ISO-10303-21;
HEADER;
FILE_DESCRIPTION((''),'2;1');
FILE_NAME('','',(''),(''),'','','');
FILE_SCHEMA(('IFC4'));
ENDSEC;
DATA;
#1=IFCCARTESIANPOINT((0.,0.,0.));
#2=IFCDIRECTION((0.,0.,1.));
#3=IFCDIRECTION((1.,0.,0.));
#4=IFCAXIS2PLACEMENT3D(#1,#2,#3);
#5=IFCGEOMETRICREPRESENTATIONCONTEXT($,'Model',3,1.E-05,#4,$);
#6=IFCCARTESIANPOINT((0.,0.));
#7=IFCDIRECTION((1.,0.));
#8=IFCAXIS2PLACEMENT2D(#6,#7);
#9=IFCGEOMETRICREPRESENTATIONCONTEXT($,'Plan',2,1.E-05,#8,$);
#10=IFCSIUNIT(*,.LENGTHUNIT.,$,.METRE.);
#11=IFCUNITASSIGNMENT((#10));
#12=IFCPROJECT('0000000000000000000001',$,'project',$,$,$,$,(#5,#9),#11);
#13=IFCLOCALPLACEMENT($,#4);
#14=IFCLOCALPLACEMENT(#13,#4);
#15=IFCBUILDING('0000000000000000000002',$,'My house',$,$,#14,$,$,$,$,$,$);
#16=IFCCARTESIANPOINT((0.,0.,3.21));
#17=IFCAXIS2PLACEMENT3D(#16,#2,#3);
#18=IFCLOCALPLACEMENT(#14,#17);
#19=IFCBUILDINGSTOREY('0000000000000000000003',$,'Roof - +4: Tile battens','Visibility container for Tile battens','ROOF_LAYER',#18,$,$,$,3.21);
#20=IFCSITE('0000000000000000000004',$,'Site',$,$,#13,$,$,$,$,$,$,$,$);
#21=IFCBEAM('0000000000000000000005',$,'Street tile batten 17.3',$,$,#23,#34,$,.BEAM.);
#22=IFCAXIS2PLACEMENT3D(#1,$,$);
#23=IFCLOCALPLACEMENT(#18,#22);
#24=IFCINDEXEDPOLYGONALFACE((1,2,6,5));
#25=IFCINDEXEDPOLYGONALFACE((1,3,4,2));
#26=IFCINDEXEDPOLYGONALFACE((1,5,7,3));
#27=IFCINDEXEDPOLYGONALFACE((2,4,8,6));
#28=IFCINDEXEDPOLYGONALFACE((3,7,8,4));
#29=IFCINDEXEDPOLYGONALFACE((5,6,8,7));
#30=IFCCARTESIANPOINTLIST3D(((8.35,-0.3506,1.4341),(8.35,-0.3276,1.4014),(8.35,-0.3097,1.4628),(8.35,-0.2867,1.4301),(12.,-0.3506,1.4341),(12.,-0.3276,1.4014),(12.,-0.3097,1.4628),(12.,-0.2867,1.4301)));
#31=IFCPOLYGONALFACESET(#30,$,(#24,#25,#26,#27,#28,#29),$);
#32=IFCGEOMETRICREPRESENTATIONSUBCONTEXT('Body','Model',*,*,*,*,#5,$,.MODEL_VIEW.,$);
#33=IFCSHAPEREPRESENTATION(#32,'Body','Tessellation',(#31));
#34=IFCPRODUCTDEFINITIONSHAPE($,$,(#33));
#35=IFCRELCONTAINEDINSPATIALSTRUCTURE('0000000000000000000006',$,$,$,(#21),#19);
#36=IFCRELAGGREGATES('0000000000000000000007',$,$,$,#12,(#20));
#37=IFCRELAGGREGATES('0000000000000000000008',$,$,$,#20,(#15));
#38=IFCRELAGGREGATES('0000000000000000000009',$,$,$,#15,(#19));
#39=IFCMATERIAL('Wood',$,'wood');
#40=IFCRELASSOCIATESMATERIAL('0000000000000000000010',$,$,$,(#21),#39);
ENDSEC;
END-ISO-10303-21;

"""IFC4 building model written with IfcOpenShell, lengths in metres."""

from ifc_helpers import new_model, si_unit, frame, origin_with_axes, origin_2d_with_axis, place, context, subcontext, project, spatial, rectangle, extrude, clip, halfspace, material, element, save


model = new_model("IFC4")

# Units and contexts
model_context = context("Model", 3, precision=1e-05, world=origin_with_axes())
plan_context = context("Plan", 2, precision=1e-05, world=origin_2d_with_axis())
body_context = subcontext(model_context, "Body", "Model", "MODEL_VIEW")
ifc_project = project(units=[si_unit("LENGTHUNIT", "METRE")], contexts=[model_context, plan_context])

# Site, building, storey
site_placement = place(None, origin_with_axes())
site = spatial("IfcSite", under=ifc_project, at=site_placement, Name="Site")
building_placement = place(site_placement, origin_with_axes())
building = spatial("IfcBuilding", under=site, at=building_placement, Name="My house")
storey_placement = place(building_placement, frame((0.0, 0.0, 3.21), z_axis=(0.0, 0.0, 1.0), x_axis=(1.0, 0.0, 0.0)))
storey = spatial("IfcBuildingStorey", under=building, at=storey_placement, Name="Roof - +4: Tile battens", Description="Visibility container for Tile battens", ObjectType="ROOF_LAYER", Elevation=3.21)

# Beam
ifc_material = material(Name="Wood", Category="wood")
beam_1_placement = place(storey_placement, frame((8.35, -0.3186, 1.4321), z_axis=(0.0, -0.575329, 0.817922), x_axis=(1.0, 0.0, 0.0)))
element("IfcBeam", 1, at=beam_1_placement, inside=storey, material=ifc_material, Name="Street tile batten 17.3", PredefinedType="BEAM", context=body_context, shape_type="Clipping", body=[
    clip(clip(extrude(rectangle(XDim=0.05, YDim=0.04), frame((0.0, 0.0, 0.0), z_axis=(1.0, 0.0, 0.0), x_axis=(0.0, 1.0, 0.0)), (0.0, 0.0, 1.0), 3.65), halfspace(frame((-8.35, 0.8616, -6.2815), z_axis=(0.0, 0.817922, -0.575329), x_axis=(1.0, 0.0, 0.0)), False)), halfspace(frame((-8.35, -2.7373, -3.7501), z_axis=(0.0, -0.817922, 0.575329), x_axis=(-1.0, 0.0, 0.0)), False)),
])

save(model, "model.ifc")
